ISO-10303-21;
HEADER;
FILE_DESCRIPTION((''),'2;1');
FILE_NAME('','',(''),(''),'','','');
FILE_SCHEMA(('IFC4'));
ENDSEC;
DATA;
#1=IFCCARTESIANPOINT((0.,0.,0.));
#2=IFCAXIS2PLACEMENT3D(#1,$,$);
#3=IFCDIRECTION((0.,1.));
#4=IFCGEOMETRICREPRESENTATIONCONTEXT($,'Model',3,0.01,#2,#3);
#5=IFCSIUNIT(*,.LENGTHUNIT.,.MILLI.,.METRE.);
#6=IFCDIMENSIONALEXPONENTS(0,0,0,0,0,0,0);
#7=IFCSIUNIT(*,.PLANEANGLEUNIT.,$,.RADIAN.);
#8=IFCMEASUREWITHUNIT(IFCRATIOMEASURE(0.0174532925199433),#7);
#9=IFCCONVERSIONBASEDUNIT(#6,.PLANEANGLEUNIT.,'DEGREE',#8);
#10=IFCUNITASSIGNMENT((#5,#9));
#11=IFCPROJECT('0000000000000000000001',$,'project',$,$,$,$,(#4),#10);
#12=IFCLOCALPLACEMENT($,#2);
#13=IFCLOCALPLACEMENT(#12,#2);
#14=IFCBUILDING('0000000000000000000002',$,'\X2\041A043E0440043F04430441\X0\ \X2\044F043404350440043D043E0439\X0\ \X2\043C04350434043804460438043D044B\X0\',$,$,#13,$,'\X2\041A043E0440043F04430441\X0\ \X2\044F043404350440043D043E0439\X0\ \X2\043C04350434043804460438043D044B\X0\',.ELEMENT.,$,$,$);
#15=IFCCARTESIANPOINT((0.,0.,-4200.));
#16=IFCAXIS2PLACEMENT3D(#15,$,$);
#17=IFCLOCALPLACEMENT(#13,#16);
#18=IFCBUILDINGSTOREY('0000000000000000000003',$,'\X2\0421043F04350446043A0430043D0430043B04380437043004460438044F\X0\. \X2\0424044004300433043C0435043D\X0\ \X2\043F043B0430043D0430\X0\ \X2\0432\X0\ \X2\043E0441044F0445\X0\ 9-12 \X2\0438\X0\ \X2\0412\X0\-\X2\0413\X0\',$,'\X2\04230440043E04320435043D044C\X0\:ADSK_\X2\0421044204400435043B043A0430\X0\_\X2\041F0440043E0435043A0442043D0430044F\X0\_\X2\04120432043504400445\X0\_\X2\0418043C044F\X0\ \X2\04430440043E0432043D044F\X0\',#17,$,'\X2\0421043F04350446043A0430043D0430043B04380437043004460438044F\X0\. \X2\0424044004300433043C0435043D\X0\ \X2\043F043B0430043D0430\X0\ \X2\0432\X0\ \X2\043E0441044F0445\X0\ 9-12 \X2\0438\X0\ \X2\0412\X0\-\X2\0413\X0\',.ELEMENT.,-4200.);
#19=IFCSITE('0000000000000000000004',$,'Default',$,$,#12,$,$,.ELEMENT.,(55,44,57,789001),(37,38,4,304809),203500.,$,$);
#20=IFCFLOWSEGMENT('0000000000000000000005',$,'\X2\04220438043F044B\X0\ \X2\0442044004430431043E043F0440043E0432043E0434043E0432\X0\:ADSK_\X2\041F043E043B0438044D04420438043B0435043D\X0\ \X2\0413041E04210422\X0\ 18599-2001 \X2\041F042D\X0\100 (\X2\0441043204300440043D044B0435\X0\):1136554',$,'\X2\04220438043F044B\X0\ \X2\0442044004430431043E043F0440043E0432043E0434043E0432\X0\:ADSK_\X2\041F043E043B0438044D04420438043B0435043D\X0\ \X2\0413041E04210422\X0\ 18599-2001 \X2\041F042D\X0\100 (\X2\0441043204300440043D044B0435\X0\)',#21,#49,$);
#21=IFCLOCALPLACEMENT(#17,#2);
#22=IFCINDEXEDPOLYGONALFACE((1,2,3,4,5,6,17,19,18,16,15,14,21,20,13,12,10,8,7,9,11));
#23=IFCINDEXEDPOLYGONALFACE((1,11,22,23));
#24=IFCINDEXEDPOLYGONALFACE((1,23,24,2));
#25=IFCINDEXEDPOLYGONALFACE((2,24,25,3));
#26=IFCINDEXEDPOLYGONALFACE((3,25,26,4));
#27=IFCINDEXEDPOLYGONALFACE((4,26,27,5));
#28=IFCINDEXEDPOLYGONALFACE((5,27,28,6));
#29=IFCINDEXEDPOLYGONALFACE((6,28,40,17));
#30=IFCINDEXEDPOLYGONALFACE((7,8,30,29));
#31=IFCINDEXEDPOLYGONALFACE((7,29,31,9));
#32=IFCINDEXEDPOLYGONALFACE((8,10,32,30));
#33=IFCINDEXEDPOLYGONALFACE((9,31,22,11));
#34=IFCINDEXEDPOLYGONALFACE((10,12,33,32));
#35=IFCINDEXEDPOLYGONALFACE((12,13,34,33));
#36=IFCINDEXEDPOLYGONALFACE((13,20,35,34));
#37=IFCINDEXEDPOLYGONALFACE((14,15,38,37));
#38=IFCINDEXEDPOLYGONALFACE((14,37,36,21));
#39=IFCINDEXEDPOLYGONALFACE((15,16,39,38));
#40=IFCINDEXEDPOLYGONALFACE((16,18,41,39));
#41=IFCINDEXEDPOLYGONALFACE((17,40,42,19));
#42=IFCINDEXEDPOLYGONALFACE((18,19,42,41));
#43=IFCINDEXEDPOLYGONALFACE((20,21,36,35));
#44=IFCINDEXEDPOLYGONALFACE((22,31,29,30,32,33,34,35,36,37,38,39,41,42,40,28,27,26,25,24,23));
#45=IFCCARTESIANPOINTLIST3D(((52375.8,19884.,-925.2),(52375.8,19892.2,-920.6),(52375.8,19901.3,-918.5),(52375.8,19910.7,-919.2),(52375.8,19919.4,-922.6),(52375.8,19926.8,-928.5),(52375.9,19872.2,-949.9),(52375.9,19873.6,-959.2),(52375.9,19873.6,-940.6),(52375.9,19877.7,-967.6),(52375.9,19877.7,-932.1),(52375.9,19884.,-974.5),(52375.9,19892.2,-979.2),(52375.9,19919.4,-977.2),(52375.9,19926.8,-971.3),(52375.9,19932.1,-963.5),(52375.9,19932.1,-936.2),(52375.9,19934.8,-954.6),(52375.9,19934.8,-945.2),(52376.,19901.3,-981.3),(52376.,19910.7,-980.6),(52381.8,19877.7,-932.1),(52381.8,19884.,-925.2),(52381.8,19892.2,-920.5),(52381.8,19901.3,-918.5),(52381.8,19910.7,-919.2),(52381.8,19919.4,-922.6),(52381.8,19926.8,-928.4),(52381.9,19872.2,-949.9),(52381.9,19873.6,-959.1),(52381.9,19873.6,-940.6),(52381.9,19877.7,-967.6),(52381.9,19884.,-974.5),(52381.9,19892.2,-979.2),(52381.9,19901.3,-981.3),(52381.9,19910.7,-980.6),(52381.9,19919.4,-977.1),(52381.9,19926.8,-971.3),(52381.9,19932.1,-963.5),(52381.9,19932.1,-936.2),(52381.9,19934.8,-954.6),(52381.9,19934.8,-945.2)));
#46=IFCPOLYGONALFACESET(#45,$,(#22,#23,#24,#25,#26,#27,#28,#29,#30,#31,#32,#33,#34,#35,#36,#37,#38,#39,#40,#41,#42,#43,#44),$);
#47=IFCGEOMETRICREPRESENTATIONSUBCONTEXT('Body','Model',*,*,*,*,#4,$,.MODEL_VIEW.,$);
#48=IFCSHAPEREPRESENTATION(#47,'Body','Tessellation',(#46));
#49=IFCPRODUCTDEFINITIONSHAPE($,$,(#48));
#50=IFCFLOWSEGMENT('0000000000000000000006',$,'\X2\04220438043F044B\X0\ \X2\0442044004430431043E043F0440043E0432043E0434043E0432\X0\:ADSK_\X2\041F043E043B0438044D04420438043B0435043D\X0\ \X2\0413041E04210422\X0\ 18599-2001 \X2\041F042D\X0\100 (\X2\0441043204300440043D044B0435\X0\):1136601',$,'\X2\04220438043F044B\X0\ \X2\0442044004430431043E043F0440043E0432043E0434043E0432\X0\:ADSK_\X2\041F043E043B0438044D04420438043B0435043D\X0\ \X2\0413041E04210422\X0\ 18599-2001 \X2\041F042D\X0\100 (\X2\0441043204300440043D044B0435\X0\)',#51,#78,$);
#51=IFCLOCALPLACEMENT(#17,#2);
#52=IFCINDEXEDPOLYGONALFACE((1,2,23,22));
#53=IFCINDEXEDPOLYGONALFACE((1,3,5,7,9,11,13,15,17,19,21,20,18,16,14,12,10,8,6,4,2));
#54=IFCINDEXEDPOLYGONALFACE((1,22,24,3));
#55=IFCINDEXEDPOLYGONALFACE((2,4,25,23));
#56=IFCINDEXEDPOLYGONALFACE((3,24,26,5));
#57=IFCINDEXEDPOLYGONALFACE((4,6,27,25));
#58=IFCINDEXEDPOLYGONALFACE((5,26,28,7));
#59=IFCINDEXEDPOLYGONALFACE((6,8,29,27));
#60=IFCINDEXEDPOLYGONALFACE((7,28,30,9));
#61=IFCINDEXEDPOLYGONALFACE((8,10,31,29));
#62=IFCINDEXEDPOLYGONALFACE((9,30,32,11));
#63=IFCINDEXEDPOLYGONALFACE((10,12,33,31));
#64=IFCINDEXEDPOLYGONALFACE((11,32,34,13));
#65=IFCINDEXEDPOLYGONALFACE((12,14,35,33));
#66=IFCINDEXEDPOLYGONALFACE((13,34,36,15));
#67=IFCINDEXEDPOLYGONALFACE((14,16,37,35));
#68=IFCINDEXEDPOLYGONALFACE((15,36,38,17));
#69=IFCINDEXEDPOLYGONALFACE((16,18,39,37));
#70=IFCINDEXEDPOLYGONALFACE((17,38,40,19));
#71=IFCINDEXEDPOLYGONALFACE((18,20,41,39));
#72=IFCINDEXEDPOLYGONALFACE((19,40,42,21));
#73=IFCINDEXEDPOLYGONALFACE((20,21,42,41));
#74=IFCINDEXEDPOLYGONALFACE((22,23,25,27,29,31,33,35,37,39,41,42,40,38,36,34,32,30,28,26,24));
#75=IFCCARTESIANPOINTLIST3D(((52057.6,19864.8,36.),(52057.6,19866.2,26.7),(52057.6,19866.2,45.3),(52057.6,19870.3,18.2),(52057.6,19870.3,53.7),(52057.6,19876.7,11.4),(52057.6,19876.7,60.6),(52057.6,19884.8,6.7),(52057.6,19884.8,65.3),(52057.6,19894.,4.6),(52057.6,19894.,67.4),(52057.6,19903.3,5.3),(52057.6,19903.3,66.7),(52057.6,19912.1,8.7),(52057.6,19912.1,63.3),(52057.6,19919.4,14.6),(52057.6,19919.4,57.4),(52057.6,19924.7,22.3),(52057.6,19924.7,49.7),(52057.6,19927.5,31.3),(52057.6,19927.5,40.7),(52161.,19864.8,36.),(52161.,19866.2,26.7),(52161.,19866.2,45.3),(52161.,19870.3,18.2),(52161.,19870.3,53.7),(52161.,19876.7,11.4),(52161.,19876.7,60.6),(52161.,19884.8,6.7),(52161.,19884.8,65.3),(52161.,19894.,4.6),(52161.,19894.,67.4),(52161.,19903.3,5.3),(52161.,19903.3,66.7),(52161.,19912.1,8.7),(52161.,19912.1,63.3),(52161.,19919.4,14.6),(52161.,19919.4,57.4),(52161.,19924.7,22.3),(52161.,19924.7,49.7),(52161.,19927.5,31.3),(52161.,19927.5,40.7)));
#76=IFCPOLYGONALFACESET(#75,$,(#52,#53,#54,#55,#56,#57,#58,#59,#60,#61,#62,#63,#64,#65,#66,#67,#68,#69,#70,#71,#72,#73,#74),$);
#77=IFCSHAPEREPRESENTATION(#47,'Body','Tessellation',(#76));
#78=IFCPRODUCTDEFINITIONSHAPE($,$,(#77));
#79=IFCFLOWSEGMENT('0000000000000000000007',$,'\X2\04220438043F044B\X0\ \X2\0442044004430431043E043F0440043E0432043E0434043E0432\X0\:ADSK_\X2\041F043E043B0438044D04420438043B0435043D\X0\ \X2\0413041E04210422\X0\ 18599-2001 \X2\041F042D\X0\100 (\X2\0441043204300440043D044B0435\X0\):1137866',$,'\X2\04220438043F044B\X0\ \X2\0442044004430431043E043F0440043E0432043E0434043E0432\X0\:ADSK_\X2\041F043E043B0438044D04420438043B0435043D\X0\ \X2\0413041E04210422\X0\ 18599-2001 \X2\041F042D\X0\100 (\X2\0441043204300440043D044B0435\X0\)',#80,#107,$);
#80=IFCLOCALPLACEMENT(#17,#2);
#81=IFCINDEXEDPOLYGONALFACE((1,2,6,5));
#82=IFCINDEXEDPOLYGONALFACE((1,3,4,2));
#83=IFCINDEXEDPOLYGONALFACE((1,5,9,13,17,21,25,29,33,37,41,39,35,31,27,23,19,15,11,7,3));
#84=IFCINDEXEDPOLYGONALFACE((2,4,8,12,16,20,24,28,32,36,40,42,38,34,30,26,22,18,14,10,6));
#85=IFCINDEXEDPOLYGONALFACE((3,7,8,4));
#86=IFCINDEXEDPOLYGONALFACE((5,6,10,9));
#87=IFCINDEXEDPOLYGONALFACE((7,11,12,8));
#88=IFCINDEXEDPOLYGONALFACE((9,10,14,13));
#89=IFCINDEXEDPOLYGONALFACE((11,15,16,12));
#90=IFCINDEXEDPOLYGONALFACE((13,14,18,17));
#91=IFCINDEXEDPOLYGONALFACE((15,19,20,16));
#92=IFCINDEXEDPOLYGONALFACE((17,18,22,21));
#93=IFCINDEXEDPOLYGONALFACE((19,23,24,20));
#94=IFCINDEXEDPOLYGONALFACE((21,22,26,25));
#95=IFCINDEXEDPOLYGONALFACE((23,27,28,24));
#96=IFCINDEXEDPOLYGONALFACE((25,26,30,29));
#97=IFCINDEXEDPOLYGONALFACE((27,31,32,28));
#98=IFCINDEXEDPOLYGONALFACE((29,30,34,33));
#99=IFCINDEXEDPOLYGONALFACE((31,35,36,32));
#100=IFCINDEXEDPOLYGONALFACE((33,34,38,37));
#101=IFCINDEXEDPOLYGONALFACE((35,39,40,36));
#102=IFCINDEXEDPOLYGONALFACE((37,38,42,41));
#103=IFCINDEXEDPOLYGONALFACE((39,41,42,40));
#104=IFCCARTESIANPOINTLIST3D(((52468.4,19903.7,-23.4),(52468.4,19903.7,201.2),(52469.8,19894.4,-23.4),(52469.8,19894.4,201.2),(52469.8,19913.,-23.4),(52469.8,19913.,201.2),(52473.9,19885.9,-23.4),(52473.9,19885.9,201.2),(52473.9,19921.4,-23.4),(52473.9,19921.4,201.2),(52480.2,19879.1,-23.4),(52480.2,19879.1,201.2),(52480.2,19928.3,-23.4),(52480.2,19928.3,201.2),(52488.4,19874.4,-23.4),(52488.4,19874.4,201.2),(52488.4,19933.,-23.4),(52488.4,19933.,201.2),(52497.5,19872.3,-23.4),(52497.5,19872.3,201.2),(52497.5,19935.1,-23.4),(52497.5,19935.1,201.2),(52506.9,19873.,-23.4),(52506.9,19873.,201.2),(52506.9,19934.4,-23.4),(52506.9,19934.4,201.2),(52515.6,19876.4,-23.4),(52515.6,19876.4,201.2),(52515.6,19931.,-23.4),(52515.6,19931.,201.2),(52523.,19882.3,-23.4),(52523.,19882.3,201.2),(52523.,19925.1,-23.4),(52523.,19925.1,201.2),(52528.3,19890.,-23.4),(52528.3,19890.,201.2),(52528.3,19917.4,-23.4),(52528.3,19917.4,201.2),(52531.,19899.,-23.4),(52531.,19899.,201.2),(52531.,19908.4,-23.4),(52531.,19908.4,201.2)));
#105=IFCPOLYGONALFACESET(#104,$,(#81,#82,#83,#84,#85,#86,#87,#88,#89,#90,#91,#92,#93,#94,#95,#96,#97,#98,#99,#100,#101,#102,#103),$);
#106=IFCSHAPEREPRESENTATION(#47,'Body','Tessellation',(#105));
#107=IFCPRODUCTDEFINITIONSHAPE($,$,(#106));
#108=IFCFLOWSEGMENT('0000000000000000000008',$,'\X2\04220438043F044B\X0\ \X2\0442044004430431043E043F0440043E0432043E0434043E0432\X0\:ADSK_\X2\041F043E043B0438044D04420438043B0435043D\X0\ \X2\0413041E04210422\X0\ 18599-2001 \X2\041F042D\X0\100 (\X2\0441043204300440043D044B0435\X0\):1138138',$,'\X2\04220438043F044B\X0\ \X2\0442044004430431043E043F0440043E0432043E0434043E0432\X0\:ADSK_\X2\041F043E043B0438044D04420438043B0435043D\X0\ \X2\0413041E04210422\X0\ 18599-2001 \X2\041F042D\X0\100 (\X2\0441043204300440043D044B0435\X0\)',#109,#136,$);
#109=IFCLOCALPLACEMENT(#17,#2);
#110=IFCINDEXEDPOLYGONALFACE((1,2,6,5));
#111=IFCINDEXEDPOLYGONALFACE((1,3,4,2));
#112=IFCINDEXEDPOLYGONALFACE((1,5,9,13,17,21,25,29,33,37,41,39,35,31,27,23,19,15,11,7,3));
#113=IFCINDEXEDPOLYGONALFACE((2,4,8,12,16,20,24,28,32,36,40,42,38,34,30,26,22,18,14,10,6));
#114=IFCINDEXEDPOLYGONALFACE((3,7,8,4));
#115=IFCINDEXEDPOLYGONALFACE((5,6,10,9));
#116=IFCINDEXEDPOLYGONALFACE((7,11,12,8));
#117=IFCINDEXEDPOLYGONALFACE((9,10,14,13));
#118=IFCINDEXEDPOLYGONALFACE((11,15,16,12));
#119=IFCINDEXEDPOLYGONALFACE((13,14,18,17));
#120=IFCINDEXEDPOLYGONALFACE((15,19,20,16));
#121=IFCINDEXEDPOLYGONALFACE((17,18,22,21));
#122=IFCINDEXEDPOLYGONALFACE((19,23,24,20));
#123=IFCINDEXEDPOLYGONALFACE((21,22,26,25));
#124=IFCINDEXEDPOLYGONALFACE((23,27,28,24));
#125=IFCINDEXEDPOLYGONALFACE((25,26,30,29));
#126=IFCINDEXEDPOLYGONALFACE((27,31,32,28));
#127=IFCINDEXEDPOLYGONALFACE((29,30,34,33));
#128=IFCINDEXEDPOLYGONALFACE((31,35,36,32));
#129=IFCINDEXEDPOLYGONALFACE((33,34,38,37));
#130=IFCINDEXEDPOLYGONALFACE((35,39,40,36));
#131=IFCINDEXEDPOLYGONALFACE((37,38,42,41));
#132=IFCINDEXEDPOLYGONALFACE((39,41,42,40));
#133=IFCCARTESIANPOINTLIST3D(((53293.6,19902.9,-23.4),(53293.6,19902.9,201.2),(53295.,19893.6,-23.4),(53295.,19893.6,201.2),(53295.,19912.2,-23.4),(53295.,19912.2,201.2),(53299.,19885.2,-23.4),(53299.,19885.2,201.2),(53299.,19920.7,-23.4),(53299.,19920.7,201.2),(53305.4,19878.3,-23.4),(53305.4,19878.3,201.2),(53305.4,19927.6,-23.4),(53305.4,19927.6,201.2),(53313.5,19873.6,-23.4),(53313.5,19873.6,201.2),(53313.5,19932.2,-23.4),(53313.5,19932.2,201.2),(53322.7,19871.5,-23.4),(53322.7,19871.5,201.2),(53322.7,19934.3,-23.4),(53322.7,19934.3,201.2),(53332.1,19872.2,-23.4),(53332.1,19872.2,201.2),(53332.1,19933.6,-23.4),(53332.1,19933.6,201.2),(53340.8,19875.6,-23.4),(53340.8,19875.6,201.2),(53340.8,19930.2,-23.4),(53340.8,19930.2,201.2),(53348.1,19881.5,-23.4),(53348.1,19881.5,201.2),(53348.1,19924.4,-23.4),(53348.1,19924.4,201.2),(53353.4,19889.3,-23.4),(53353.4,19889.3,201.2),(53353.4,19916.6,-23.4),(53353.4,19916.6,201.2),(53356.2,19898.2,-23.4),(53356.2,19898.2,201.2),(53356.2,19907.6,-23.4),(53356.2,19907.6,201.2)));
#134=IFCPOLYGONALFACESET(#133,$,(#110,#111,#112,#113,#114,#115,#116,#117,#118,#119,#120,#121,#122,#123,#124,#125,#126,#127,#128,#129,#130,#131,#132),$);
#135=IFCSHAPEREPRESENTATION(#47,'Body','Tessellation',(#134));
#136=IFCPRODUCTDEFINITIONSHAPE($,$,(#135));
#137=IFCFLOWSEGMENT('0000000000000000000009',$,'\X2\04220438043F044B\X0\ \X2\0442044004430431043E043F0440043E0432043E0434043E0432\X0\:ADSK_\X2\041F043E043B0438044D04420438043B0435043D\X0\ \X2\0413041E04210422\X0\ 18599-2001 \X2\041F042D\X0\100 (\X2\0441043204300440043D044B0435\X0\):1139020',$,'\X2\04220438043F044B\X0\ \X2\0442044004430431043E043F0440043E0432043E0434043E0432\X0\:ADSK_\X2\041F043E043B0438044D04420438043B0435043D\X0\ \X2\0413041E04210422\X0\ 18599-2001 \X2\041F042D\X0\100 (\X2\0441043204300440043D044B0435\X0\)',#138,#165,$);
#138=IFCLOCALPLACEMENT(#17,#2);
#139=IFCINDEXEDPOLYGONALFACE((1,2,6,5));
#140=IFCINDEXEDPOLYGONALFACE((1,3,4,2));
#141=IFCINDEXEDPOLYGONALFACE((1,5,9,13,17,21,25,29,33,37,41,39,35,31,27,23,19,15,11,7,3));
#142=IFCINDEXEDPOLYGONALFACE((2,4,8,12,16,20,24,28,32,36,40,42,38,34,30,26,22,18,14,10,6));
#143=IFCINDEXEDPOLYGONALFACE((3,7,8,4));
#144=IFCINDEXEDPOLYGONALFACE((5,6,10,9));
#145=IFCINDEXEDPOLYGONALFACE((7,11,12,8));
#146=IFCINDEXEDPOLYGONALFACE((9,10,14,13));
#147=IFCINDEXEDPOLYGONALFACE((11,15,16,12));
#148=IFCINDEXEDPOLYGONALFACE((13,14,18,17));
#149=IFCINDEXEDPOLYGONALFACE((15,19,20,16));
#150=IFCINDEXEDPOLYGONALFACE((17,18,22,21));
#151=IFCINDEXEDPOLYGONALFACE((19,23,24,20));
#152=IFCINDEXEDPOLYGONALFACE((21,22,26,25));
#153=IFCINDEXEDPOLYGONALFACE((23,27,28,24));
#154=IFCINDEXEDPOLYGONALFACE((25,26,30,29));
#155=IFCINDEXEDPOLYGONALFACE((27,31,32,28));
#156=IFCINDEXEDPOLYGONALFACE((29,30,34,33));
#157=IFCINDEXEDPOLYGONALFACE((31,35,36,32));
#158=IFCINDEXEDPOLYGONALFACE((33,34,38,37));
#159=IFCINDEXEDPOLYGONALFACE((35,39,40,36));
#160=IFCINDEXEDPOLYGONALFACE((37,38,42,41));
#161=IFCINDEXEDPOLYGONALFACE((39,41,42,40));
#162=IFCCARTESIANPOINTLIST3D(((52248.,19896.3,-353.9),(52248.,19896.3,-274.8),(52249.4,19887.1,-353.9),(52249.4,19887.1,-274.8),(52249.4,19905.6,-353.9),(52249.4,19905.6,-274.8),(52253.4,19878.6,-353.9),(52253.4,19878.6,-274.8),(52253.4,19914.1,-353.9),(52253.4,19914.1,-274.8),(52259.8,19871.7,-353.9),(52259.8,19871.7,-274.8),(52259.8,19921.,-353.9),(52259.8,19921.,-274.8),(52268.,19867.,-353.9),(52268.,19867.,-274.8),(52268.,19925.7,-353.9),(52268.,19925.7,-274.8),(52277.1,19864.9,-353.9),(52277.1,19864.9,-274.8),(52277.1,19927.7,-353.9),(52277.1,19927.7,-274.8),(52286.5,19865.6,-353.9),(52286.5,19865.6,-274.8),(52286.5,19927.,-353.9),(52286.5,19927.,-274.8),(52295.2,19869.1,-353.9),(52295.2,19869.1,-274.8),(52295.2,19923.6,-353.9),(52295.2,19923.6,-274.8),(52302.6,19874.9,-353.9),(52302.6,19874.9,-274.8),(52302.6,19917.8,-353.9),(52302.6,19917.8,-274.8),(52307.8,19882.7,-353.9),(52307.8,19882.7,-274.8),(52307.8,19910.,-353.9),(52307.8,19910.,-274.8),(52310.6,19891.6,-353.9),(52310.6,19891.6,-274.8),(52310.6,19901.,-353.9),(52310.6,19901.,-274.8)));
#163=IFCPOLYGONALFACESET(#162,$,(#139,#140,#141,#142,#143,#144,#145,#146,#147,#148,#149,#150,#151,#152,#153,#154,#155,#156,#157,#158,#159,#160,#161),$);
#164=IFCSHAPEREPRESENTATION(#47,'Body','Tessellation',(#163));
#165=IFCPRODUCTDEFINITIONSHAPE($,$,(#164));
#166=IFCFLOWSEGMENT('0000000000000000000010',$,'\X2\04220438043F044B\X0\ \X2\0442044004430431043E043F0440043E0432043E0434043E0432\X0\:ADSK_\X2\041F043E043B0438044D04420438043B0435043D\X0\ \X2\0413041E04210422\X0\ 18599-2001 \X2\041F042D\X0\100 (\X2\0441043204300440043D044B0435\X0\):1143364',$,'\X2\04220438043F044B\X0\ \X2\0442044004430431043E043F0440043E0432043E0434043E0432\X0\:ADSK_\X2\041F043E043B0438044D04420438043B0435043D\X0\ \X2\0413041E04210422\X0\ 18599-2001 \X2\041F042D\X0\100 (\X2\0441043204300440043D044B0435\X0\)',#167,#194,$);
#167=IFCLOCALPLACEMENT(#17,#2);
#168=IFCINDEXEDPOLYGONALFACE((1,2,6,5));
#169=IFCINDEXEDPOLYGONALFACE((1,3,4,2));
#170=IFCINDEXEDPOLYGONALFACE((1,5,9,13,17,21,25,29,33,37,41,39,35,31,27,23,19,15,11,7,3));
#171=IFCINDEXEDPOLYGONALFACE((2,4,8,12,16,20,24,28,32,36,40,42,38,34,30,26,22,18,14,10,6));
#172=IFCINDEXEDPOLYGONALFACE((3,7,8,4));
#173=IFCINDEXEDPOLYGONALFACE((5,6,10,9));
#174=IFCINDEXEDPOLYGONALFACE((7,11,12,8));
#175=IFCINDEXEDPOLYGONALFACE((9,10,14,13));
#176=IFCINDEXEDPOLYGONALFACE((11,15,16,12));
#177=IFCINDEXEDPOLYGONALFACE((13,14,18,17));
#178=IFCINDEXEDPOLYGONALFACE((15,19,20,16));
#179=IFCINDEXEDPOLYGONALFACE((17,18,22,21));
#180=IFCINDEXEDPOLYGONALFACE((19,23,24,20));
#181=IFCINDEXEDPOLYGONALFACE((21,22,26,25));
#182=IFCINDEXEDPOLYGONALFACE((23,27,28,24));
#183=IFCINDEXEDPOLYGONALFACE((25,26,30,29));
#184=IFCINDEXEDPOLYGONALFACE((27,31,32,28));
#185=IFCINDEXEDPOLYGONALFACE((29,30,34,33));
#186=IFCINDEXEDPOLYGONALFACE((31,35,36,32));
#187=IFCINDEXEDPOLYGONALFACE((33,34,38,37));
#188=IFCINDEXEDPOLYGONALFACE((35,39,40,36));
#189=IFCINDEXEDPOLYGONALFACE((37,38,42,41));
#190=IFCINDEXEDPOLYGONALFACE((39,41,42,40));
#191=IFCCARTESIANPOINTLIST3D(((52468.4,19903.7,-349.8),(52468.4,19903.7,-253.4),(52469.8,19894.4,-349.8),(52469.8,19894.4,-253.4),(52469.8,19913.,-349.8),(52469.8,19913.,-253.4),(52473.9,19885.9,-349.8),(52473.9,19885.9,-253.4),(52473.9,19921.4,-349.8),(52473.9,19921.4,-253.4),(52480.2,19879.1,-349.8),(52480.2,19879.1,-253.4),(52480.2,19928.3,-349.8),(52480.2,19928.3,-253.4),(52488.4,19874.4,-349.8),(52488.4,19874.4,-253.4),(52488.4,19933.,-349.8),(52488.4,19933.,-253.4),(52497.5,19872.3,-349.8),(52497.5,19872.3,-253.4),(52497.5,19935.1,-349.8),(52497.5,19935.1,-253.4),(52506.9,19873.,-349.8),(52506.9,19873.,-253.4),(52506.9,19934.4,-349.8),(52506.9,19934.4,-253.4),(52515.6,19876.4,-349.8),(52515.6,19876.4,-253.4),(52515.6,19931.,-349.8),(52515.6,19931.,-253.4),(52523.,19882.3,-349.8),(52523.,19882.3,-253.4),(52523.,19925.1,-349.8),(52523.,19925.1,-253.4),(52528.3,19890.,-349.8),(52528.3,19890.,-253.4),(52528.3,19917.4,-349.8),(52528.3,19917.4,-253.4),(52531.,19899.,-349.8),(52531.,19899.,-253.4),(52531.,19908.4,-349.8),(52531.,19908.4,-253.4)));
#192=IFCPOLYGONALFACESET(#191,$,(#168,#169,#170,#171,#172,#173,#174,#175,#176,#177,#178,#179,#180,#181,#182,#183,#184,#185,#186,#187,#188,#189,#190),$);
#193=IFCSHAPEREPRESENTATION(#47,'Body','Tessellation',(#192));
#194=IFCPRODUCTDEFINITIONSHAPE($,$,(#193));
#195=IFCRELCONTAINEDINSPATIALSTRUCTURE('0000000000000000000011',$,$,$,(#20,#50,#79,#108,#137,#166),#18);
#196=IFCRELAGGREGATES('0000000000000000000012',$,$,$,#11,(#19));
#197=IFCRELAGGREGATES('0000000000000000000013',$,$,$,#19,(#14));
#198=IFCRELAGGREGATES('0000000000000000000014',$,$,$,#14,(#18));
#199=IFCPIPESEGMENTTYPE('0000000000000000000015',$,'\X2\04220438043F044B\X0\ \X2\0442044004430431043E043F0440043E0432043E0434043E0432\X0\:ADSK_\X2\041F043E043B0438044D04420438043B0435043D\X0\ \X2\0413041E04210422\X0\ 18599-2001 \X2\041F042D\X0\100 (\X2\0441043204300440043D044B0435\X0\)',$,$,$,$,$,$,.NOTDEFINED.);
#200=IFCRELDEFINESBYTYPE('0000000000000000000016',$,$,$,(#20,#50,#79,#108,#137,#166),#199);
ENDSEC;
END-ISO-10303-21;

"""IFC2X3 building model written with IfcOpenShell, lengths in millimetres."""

from ifc_helpers import new_model, entity, si_unit, converted_unit, direction, frame, frame_2d, origin, origin_2d_with_axis, place, context, subcontext, project, spatial, circle, extrude, type_object, element, save


model = new_model("IFC2X3")

# Units and contexts
model_context = context("Model", 3, precision=0.01, world=origin(), true_north=direction((0.0, 1.0)))
body_context = subcontext(model_context, "Body", "Model", "MODEL_VIEW")
ifc_project = project(units=[si_unit("LENGTHUNIT", "METRE", prefix="MILLI"), converted_unit("PLANEANGLEUNIT", "DEGREE", entity("IfcRatioMeasure", 0.0174532925199433), si_unit("PLANEANGLEUNIT", "RADIAN"), dimensions=[0, 0, 0, 0, 0, 0, 0])], contexts=[model_context])

# Site, building, storey
site_placement = place(None, frame((0.0, 0.0, 0.0)))
site = spatial("IfcSite", under=ifc_project, at=site_placement, Name="Default", CompositionType="ELEMENT", RefLatitude=(55, 44, 57, 789001), RefLongitude=(37, 38, 4, 304809), RefElevation=203500.0)
building_placement = place(site_placement, origin())
building = spatial("IfcBuilding", under=site, at=building_placement, Name="Корпус ядерной медицины", LongName="Корпус ядерной медицины", CompositionType="ELEMENT")
storey_placement = place(building_placement, frame((0.0, 0.0, -4200.0)))
storey = spatial("IfcBuildingStorey", under=building, at=storey_placement, Name="Спецканализация. Фрагмен плана в осях 9-12 и В-Г", ObjectType="Уровень:ADSK_Стрелка_Проектная_Вверх_Имя уровня", LongName="Спецканализация. Фрагмен плана в осях 9-12 и В-Г", CompositionType="ELEMENT", Elevation=-4200.0)

# Flow segments
pipe_segment_type = type_object("IfcPipeSegmentType", Name="Типы трубопроводов:ADSK_Полиэтилен ГОСТ 18599-2001 ПЭ100 (сварные)", PredefinedType="NOTDEFINED")
flow_segment_1_placement = place(storey_placement, frame((52375.8, 19870.6, -983.0)))
element("IfcFlowSegment", 1, at=flow_segment_1_placement, inside=storey, type_object=pipe_segment_type, Name="Типы трубопроводов:ADSK_Полиэтилен ГОСТ 18599-2001 ПЭ100 (сварные):1136554", ObjectType="Типы трубопроводов:ADSK_Полиэтилен ГОСТ 18599-2001 ПЭ100 (сварные)", context=body_context, shape_type="SweptSolid", body=[
    extrude(circle(Radius=31.5, at=origin_2d_with_axis()), frame((0.1, 33.1, 33.1), z_axis=(0.999998, 0.0, 0.002), x_axis=(0.0, -1.0, 0.0)), (0.0, 0.0, 1.0), 6.0),
])
flow_segment_2_placement = place(storey_placement, frame((52057.6, 19863.2, 2.9)))
element("IfcFlowSegment", 2, at=flow_segment_2_placement, inside=storey, type_object=pipe_segment_type, Name="Типы трубопроводов:ADSK_Полиэтилен ГОСТ 18599-2001 ПЭ100 (сварные):1136601", ObjectType="Типы трубопроводов:ADSK_Полиэтилен ГОСТ 18599-2001 ПЭ100 (сварные)", context=body_context, shape_type="SweptSolid", body=[
    extrude(circle(Radius=31.5, at=frame_2d((0.0, 0.0), x_axis=(1.0, 0.0))), frame((0.0, 33.1, 33.1), z_axis=(1.0, 0.0, 0.0), x_axis=(0.0, -1.0, 0.0)), (0.0, 0.0, 1.0), 103.4),
])
flow_segment_3_placement = place(storey_placement, frame((52466.8, 19870.6, -23.4)))
element("IfcFlowSegment", 3, at=flow_segment_3_placement, inside=storey, type_object=pipe_segment_type, Name="Типы трубопроводов:ADSK_Полиэтилен ГОСТ 18599-2001 ПЭ100 (сварные):1137866", ObjectType="Типы трубопроводов:ADSK_Полиэтилен ГОСТ 18599-2001 ПЭ100 (сварные)", context=body_context, shape_type="SweptSolid", body=[
    extrude(circle(Radius=31.5, at=origin_2d_with_axis()), frame((33.1, 33.1, 0.0), z_axis=(0.000001, 0.0, 1.0), x_axis=(-1.0, 0.0, 0.000001)), (0.0, 0.0, 1.0), 224.7),
])
flow_segment_4_placement = place(storey_placement, frame((53292.0, 19869.8, -23.4)))
element("IfcFlowSegment", 4, at=flow_segment_4_placement, inside=storey, type_object=pipe_segment_type, Name="Типы трубопроводов:ADSK_Полиэтилен ГОСТ 18599-2001 ПЭ100 (сварные):1138138", ObjectType="Типы трубопроводов:ADSK_Полиэтилен ГОСТ 18599-2001 ПЭ100 (сварные)", context=body_context, shape_type="SweptSolid", body=[
    extrude(circle(Radius=31.5, at=origin_2d_with_axis()), frame((33.1, 33.1, 0.0), z_axis=(0.000002, 0.0, 1.0), x_axis=(-1.0, 0.0, 0.000002)), (0.0, 0.0, 1.0), 224.7),
])
flow_segment_5_placement = place(storey_placement, frame((52246.4, 19863.2, -353.9)))
element("IfcFlowSegment", 5, at=flow_segment_5_placement, inside=storey, type_object=pipe_segment_type, Name="Типы трубопроводов:ADSK_Полиэтилен ГОСТ 18599-2001 ПЭ100 (сварные):1139020", ObjectType="Типы трубопроводов:ADSK_Полиэтилен ГОСТ 18599-2001 ПЭ100 (сварные)", context=body_context, shape_type="SweptSolid", body=[
    extrude(circle(Radius=31.5, at=origin_2d_with_axis()), frame((33.1, 33.1, 0.0), z_axis=(0.000001, 0.0, 1.0), x_axis=(-1.0, 0.0, 0.000001)), (0.0, 0.0, 1.0), 79.1),
])
flow_segment_6_placement = place(storey_placement, frame((52466.8, 19870.6, -349.8)))
element("IfcFlowSegment", 6, at=flow_segment_6_placement, inside=storey, type_object=pipe_segment_type, Name="Типы трубопроводов:ADSK_Полиэтилен ГОСТ 18599-2001 ПЭ100 (сварные):1143364", ObjectType="Типы трубопроводов:ADSK_Полиэтилен ГОСТ 18599-2001 ПЭ100 (сварные)", context=body_context, shape_type="SweptSolid", body=[
    extrude(circle(Radius=31.5, at=origin_2d_with_axis()), frame((33.1, 33.1, 0.0), z_axis=(0.000001, 0.0, 1.0), x_axis=(-1.0, 0.0, 0.000001)), (0.0, 0.0, 1.0), 96.3),
])

save(model, "model.ifc")
